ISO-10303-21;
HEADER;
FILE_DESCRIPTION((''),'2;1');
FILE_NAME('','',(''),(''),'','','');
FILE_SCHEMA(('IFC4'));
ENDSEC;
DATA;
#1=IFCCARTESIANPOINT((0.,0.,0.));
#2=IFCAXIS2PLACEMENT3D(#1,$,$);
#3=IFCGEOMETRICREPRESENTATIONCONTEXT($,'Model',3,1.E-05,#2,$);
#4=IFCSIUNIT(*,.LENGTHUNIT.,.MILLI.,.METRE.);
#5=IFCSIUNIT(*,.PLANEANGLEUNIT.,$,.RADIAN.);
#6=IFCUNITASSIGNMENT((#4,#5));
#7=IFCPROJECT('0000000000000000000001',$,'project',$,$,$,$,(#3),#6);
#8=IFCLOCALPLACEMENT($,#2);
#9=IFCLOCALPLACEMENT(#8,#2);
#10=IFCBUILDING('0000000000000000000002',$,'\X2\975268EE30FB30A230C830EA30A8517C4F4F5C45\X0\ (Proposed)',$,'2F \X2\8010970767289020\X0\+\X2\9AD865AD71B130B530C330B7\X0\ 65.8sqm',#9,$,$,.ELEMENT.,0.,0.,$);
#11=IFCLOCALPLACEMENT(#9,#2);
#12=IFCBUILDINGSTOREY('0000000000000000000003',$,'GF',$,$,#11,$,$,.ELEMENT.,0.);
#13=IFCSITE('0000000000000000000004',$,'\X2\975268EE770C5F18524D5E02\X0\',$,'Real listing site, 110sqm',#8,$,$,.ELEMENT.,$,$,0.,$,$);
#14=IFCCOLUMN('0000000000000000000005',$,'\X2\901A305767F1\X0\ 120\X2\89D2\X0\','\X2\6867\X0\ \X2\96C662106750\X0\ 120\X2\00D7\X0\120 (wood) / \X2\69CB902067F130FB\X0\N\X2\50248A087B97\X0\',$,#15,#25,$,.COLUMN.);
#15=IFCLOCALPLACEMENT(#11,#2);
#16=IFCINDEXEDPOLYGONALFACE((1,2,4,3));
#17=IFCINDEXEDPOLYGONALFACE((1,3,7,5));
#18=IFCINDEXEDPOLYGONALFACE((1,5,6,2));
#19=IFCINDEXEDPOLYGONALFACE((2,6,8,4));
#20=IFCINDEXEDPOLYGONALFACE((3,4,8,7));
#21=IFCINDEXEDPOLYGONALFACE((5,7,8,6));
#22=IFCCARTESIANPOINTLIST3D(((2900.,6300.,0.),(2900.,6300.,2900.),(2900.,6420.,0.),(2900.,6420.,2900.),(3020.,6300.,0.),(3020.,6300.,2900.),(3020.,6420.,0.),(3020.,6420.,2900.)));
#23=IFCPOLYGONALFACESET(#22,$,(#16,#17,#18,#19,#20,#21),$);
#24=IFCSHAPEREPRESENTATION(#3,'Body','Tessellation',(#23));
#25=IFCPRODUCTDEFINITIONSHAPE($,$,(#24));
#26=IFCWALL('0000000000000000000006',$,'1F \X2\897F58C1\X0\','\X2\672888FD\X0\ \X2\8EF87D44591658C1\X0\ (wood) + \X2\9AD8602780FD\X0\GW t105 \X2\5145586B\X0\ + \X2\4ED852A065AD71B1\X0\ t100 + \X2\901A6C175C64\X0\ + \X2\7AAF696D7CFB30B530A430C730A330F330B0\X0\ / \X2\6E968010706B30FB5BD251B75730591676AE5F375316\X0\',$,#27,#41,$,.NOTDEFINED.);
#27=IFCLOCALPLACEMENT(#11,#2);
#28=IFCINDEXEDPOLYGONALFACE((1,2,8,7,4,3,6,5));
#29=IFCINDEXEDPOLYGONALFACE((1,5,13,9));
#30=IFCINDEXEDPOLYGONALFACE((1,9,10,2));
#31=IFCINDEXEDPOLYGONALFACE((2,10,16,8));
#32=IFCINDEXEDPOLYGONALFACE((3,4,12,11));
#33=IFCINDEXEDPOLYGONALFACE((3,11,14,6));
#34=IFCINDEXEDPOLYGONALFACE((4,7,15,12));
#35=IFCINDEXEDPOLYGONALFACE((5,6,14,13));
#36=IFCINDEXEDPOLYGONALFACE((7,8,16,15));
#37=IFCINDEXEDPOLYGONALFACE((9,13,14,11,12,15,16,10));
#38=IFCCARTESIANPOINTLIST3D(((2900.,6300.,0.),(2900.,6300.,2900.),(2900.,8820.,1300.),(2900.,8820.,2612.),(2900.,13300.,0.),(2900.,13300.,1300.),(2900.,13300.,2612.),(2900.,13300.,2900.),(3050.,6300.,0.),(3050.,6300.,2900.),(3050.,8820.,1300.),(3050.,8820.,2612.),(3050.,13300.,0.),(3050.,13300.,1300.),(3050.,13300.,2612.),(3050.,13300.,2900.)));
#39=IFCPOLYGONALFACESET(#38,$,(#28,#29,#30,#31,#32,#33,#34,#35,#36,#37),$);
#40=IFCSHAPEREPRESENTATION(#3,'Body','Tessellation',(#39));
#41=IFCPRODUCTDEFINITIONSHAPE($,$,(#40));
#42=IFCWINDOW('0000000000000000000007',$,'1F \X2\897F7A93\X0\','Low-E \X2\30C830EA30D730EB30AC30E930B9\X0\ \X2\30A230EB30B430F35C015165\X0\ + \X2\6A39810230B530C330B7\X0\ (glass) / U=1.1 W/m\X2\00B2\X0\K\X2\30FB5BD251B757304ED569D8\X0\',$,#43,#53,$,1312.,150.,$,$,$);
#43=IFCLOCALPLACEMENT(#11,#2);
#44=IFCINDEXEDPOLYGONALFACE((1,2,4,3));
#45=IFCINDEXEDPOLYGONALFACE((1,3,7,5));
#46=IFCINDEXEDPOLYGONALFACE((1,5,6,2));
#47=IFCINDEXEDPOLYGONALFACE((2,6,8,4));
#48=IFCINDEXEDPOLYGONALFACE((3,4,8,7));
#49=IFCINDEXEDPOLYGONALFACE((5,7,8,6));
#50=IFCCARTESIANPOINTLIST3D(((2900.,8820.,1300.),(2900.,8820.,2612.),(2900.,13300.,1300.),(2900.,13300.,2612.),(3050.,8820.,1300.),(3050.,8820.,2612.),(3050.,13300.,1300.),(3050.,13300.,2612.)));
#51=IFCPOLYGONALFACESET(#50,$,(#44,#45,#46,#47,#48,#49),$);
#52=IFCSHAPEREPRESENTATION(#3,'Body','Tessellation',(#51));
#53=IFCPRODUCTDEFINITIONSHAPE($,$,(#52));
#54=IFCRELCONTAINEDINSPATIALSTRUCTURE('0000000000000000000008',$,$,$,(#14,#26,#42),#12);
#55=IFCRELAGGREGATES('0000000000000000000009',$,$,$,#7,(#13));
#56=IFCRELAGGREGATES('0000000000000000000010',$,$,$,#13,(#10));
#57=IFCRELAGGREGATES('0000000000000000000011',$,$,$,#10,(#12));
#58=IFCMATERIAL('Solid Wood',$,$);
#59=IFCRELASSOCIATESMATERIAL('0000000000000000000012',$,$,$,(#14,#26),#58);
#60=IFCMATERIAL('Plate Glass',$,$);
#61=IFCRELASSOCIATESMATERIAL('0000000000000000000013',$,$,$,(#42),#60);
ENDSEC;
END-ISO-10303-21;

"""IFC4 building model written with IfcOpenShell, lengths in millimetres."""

from ifc_helpers import new_model, si_unit, frame, frame_2d, origin, place, context, project, spatial, rectangle, extrude, material, element, fill, save


model = new_model("IFC4")

# Units and contexts
model_context = context("Model", 3, precision=1e-05, world=origin())
ifc_project = project(units=[si_unit("LENGTHUNIT", "METRE", prefix="MILLI"), si_unit("PLANEANGLEUNIT", "RADIAN")], contexts=[model_context])

# Site, building, storey
site_placement = place(None, origin())
site = spatial("IfcSite", under=ifc_project, at=site_placement, Name="青森県弘前市", ObjectType="Real listing site, 110sqm", CompositionType="ELEMENT", RefElevation=0.0)
building_placement = place(site_placement, origin())
building = spatial("IfcBuilding", under=site, at=building_placement, Name="青森・アトリエ兼住居 (Proposed)", ObjectType="2F 耐震木造+高断熱サッシ 65.8sqm", CompositionType="ELEMENT", ElevationOfRefHeight=0.0, ElevationOfTerrain=0.0)
storey_placement = place(building_placement, origin())
storey = spatial("IfcBuildingStorey", under=building, at=storey_placement, Name="GF", CompositionType="ELEMENT", Elevation=0.0)

# Column
ifc_material_1 = material(Name="Solid Wood")
column_1_placement = place(storey_placement, frame((1450.0, 3150.0, 0.0)))
element("IfcColumn", 1, at=column_1_placement, inside=storey, material=ifc_material_1, Name="通し柱 120角", Description="桧 集成材 120×120 (wood) / 構造柱・N値計算", PredefinedType="COLUMN", context=model_context, shape_type="SweptSolid", body=[
    extrude(rectangle(XDim=120.0, YDim=120.0, at=frame_2d((60.0, 60.0))), frame((1450.0, 3150.0, 0.0)), (0.0, 0.0, 1.0), 2900.0),
])

# Shared definitions
ifc_material_2 = material(Name="Plate Glass")

# Wall, opening, window
wall_1_placement = place(storey_placement, frame((1450.0, 3150.0, 0.0)))
wall_1 = element("IfcWall", 2, at=wall_1_placement, inside=storey, material=ifc_material_1, Name="1F 西壁", Description="木製 軸組外壁 (wood) + 高性能GW t105 充填 + 付加断熱 t100 + 通気層 + 窯業系サイディング / 準耐火・寒冷地外皮強化", PredefinedType="NOTDEFINED", context=model_context, shape_type="SweptSolid", body=[
    extrude(rectangle(XDim=150.0, YDim=7000.0, at=frame_2d((75.0, 3500.0))), frame((1450.0, 3150.0, 0.0)), (0.0, 0.0, 1.0), 2900.0),
])
opening_1_placement = place(storey_placement, frame((1450.0, 4410.0, 650.0)))
opening_1 = element("IfcOpeningElement", 3, at=opening_1_placement, cuts=wall_1, PredefinedType="NOTDEFINED", context=model_context, shape_type="SweptSolid", body=[
    extrude(rectangle(XDim=150.0, YDim=4480.0, at=frame_2d((75.0, 2240.0))), frame((1450.0, 4410.0, 650.0)), (0.0, 0.0, 1.0), 1312.0),
])
window_1_placement = place(storey_placement, frame((1450.0, 4410.0, 650.0)))
window_1 = element("IfcWindow", 4, at=window_1_placement, inside=storey, material=ifc_material_2, Name="1F 西窓", Description="Low-E トリプルガラス アルゴン封入 + 樹脂サッシ (glass) / U=1.1 W/m²K・寒冷地仕様", OverallHeight=1312.0, OverallWidth=150.0, context=model_context, shape_type="SweptSolid", body=[
    extrude(rectangle(XDim=150.0, YDim=4480.0, at=frame_2d((75.0, 2240.0))), frame((1450.0, 4410.0, 650.0)), (0.0, 0.0, 1.0), 1312.0),
])
fill(opening_1, window_1)

save(model, "model.ifc")
